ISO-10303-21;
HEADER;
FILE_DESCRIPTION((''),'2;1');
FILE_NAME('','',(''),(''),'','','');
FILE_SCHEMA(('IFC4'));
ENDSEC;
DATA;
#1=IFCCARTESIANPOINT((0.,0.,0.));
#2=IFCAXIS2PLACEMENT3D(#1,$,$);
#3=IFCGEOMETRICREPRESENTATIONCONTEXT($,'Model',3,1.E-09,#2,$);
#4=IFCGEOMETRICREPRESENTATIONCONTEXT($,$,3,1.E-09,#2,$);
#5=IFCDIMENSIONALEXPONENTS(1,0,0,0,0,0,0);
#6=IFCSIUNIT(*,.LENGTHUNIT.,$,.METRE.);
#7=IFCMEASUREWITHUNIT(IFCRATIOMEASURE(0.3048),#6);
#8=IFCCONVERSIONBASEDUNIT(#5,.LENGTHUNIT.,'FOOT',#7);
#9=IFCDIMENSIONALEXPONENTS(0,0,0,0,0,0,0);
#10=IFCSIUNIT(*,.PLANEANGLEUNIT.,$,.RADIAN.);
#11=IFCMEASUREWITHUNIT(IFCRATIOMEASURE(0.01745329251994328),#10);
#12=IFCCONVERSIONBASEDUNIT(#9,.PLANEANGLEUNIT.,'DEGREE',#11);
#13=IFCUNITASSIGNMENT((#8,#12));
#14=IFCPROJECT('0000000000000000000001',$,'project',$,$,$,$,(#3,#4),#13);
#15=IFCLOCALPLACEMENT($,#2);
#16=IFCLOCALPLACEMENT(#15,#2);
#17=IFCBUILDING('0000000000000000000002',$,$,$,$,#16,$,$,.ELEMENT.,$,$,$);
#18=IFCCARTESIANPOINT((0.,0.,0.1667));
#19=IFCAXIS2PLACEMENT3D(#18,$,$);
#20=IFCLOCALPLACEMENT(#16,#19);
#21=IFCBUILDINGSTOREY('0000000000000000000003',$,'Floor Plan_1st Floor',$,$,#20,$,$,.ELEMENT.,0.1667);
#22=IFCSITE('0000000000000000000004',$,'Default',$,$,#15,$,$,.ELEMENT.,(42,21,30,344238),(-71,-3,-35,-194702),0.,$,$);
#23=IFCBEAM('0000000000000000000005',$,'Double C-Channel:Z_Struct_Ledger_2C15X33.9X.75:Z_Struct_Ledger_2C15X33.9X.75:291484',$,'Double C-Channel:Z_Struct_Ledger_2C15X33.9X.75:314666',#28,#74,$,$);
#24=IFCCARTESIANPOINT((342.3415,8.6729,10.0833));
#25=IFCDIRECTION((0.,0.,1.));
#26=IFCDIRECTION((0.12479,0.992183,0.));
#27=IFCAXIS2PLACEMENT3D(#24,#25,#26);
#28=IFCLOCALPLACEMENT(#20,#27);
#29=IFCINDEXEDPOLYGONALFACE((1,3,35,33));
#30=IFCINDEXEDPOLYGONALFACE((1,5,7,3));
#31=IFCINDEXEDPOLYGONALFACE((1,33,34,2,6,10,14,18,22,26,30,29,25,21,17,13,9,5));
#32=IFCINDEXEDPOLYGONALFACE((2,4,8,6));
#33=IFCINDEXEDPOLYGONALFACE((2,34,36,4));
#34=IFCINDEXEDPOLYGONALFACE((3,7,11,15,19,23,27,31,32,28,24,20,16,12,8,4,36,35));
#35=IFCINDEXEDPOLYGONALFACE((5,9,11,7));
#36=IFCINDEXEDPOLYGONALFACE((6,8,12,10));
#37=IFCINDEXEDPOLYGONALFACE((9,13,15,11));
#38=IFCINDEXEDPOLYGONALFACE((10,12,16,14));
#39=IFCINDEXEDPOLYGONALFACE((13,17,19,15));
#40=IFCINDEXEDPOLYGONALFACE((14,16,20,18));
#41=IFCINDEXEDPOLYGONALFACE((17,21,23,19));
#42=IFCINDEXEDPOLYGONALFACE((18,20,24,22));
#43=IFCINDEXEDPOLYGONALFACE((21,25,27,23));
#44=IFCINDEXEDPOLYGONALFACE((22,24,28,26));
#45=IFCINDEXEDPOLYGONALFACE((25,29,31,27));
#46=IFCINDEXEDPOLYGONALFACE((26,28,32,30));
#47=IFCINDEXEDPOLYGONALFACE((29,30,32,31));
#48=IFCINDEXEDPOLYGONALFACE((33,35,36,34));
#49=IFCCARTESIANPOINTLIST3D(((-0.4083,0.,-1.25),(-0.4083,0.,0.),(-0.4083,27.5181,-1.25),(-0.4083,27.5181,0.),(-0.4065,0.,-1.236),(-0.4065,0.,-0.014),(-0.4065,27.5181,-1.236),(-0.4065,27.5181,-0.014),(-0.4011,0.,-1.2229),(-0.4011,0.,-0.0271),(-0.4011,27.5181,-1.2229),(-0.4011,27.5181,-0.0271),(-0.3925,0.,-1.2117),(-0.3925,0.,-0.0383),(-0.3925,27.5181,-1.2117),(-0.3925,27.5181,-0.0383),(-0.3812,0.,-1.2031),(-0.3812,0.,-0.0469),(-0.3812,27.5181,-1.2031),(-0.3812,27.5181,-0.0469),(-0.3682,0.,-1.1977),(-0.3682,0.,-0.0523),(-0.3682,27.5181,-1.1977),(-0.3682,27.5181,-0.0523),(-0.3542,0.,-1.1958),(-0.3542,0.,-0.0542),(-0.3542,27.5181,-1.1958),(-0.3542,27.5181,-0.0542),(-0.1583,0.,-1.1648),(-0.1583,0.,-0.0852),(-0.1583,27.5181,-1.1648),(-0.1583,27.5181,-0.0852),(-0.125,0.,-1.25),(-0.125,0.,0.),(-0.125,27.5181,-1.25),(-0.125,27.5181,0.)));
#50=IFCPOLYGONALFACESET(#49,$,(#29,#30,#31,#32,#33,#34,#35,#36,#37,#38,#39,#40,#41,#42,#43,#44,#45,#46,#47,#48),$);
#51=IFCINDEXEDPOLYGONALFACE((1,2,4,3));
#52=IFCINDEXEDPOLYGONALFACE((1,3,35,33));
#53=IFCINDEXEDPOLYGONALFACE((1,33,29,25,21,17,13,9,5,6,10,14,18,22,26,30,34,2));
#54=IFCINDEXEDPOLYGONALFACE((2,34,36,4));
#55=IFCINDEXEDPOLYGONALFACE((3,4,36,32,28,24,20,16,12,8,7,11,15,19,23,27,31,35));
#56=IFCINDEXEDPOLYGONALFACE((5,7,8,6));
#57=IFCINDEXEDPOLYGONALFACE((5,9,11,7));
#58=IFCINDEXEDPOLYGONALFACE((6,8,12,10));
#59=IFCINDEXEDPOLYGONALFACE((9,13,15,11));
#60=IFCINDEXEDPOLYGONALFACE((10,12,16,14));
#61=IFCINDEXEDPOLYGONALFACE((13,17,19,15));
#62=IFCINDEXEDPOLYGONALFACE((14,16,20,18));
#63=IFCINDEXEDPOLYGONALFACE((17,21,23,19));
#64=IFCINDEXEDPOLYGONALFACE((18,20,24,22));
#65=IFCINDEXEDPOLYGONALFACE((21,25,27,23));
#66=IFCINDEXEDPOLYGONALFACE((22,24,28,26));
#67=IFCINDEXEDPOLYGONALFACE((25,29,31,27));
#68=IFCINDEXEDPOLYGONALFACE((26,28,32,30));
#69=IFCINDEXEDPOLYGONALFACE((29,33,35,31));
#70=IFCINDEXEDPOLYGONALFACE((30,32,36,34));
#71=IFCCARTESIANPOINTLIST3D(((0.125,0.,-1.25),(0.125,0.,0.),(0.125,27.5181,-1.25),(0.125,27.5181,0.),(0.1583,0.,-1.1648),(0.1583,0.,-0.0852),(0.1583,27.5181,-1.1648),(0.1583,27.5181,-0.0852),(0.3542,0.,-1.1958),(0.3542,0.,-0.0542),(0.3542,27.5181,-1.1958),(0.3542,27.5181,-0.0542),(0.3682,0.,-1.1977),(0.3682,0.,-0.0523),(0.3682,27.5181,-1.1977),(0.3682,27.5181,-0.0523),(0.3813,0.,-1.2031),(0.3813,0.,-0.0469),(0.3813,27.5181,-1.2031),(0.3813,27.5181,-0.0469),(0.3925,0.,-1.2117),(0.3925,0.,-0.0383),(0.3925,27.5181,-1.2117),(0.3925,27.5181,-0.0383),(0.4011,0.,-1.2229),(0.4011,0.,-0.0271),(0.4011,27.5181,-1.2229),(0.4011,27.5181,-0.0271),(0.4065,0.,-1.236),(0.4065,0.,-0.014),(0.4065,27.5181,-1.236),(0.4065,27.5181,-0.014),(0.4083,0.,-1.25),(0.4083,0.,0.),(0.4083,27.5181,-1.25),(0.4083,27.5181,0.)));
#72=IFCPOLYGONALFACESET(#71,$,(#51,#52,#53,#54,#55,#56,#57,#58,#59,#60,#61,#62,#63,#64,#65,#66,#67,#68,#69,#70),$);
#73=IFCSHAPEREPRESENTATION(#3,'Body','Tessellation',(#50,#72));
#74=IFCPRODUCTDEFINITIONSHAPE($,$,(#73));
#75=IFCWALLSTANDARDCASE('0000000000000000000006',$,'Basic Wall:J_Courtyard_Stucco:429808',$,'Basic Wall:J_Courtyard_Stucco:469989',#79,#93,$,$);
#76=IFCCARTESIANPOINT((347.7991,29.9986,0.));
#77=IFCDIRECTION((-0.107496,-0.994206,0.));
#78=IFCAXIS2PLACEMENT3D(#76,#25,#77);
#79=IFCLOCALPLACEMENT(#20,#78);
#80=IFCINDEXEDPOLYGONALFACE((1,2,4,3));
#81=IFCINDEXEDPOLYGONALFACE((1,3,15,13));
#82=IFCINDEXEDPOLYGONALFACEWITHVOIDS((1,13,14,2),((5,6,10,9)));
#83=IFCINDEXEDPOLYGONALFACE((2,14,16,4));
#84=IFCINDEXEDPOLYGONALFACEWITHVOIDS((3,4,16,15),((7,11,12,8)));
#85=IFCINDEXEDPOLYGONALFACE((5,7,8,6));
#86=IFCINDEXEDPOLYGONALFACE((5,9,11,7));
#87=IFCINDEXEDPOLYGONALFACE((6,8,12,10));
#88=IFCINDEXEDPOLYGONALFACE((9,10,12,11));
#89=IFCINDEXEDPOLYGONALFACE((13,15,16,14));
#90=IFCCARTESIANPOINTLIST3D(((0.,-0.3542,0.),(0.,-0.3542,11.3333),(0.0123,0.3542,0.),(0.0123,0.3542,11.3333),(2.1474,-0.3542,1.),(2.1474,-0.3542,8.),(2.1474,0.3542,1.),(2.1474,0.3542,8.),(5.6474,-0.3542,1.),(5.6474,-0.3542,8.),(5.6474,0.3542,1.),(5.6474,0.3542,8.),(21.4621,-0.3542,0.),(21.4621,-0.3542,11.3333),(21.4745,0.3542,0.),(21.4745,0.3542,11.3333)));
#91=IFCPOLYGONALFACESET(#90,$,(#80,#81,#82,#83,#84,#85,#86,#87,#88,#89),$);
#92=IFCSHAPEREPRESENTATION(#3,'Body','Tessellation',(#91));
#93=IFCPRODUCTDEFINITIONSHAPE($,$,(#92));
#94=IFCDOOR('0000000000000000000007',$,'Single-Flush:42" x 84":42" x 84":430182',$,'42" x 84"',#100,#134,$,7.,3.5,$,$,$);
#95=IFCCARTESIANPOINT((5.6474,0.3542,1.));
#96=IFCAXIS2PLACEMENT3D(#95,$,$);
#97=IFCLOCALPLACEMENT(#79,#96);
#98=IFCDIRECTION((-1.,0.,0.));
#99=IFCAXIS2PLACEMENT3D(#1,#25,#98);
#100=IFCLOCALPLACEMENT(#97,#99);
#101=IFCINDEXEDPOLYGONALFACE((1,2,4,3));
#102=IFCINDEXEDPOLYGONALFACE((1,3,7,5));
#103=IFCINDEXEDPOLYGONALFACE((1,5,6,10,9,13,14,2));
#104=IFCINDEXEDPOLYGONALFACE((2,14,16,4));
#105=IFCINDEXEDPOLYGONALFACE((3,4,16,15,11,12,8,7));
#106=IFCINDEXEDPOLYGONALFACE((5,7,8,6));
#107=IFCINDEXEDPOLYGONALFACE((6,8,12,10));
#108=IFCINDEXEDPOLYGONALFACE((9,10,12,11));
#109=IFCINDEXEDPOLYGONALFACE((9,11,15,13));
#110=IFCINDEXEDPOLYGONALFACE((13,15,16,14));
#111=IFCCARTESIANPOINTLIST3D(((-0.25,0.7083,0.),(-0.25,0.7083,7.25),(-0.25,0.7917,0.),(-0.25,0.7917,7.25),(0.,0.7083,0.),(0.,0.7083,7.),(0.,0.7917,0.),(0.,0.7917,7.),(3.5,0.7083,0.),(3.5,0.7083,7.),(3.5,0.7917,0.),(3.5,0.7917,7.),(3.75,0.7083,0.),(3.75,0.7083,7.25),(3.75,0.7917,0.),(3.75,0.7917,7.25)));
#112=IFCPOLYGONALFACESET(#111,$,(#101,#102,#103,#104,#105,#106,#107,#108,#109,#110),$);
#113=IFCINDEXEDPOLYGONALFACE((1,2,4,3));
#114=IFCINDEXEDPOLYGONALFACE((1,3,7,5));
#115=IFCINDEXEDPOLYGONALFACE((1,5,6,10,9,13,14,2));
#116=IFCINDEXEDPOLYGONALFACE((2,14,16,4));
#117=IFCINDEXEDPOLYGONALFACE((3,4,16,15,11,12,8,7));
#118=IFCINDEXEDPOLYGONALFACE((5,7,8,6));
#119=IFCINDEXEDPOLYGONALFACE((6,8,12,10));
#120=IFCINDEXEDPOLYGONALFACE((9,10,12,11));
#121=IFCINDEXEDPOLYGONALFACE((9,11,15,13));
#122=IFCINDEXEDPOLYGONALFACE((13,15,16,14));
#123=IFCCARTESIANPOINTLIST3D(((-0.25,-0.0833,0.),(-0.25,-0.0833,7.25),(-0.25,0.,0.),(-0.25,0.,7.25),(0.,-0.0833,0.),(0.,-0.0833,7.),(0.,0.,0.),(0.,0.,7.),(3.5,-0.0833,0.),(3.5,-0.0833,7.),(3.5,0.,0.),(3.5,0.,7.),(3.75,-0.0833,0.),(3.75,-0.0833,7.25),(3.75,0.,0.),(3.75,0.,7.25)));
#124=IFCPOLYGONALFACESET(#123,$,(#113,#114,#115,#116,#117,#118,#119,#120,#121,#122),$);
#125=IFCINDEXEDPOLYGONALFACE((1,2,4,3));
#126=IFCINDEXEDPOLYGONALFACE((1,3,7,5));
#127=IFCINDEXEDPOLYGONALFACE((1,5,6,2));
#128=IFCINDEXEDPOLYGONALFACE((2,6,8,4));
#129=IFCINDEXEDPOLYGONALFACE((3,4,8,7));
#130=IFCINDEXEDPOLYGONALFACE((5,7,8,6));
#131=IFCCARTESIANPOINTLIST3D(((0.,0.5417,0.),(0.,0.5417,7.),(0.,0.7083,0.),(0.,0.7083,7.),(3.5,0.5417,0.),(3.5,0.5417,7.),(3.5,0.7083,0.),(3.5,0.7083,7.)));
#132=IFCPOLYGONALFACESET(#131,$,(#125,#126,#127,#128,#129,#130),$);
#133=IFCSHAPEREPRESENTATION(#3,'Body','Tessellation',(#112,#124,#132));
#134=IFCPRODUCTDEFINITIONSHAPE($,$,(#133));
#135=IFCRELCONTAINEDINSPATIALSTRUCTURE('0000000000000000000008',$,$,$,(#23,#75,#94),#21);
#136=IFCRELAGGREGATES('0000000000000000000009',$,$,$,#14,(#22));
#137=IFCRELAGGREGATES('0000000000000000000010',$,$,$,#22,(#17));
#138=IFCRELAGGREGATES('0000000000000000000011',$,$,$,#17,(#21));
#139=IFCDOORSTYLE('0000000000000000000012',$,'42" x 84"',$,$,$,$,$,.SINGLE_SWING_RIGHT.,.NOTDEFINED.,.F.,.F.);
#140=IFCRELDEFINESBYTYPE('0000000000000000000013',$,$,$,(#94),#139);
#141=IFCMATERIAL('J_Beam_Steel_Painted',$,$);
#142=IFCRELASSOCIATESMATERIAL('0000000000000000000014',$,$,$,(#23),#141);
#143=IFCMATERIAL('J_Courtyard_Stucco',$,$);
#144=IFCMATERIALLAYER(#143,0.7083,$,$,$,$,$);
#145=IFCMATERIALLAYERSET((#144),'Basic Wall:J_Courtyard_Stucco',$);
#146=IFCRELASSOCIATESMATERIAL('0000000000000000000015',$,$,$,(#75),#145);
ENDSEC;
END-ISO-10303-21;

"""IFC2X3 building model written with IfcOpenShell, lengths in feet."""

from ifc_helpers import new_model, entity, si_unit, converted_unit, frame, frame_2d, origin, origin_2d_with_axis, place, context, project, spatial, polyline, circle_curve, parameter, trimmed, segment, composite_curve, rectangle, outline, extrude, clip, halfspace, source, transform, mapped, material, layer, layer_set, layer_usage, type_object, type_shapes, element, fill, save


model = new_model("IFC2X3")

# Units and contexts
model_context = context("Model", 3, precision=1e-09, world=origin())
context_of_model = context(None, 3, precision=1e-09, world=origin())
ifc_project = project(units=[converted_unit("LENGTHUNIT", "FOOT", entity("IfcRatioMeasure", 0.3048), si_unit("LENGTHUNIT", "METRE"), dimensions=[1, 0, 0, 0, 0, 0, 0]), converted_unit("PLANEANGLEUNIT", "DEGREE", entity("IfcRatioMeasure", 0.01745329251994328), si_unit("PLANEANGLEUNIT", "RADIAN"), dimensions=[0, 0, 0, 0, 0, 0, 0])], contexts=[model_context, context_of_model])

# Site, building, storey
site_placement = place(None, origin())
site = spatial("IfcSite", under=ifc_project, at=site_placement, Name="Default", CompositionType="ELEMENT", RefLatitude=(42, 21, 30, 344238), RefLongitude=(-71, -3, -35, -194702), RefElevation=0.0)
building_placement = place(site_placement, origin())
building = spatial("IfcBuilding", under=site, at=building_placement, CompositionType="ELEMENT")
storey_placement = place(building_placement, frame((0.0, 0.0, 0.1667)))
storey = spatial("IfcBuildingStorey", under=building, at=storey_placement, Name="Floor Plan_1st Floor", CompositionType="ELEMENT", Elevation=0.1667)

# Beam
ifc_material_1 = material(Name="J_Beam_Steel_Painted")
beam_placement = place(storey_placement, frame((342.3415, 8.6729, 10.0833), z_axis=(0.0, 0.0, 1.0), x_axis=(0.12479, 0.992183, 0.0)))
element("IfcBeam", 1, at=beam_placement, inside=storey, material=ifc_material_1, Name="Double C-Channel:Z_Struct_Ledger_2C15X33.9X.75:Z_Struct_Ledger_2C15X33.9X.75:291484", ObjectType="Double C-Channel:Z_Struct_Ledger_2C15X33.9X.75:314666", context=model_context, shape_type="SweptSolid", body=[
    extrude(outline(composite_curve([segment(polyline([(-0.1365, -0.625), (0.1469, -0.625)]), True, "CONTINUOUS"), segment(trimmed(circle_curve(frame_2d((0.0927, -0.625), x_axis=(1.0, 0.0)), 0.0542), [parameter(0.0)], [parameter(90.0)], True, "PARAMETER"), True, "CONTINUOUS"), segment(polyline([(0.0927, -0.5708), (-0.1031, -0.5398)]), True, "CONTINUOUS"), segment(polyline([(-0.1031, -0.5398), (-0.1031, 0.5398)]), True, "CONTINUOUS"), segment(polyline([(-0.1031, 0.5398), (0.0927, 0.5708)]), True, "CONTINUOUS"), segment(trimmed(circle_curve(frame_2d((0.0927, 0.625), x_axis=(1.0, 0.0)), 0.0542), [parameter(270.0)], [parameter(0.0)], True, "PARAMETER"), True, "CONTINUOUS"), segment(polyline([(0.1469, 0.625), (-0.1365, 0.625)]), True, "CONTINUOUS"), segment(polyline([(-0.1365, 0.625), (-0.1365, -0.625)]), True, "CONTINUOUS")], self_intersect=False)), frame((-0.2615, 27.5181, -0.625), z_axis=(0.0, -1.0, 0.0), x_axis=(-1.0, 0.0, 0.0)), (0.0, 0.0, 1.0), 27.5181),
    extrude(outline(composite_curve([segment(polyline([(-0.625, -0.1365), (0.625, -0.1365)]), True, "CONTINUOUS"), segment(polyline([(0.625, -0.1365), (0.625, 0.1469)]), True, "CONTINUOUS"), segment(trimmed(circle_curve(frame_2d((0.625, 0.0927), x_axis=(0.0, 1.0)), 0.0542), [parameter(360.0)], [parameter(90.0)], True, "PARAMETER"), True, "CONTINUOUS"), segment(polyline([(0.5708, 0.0927), (0.5398, -0.1031)]), True, "CONTINUOUS"), segment(polyline([(0.5398, -0.1031), (-0.5398, -0.1031)]), True, "CONTINUOUS"), segment(polyline([(-0.5398, -0.1031), (-0.5708, 0.0927)]), True, "CONTINUOUS"), segment(trimmed(circle_curve(frame_2d((-0.625, 0.0927), x_axis=(0.0, 1.0)), 0.0542), [parameter(270.0)], [parameter(360.0)], True, "PARAMETER"), True, "CONTINUOUS"), segment(polyline([(-0.625, 0.1469), (-0.625, -0.1365)]), True, "CONTINUOUS")], self_intersect=False)), frame((0.2615, 27.5181, -0.625), z_axis=(0.0, -1.0, 0.0), x_axis=(0.0, 0.0, -1.0)), (0.0, 0.0, 1.0), 27.5181),
])

# Wall, opening, door
ifc_material_2 = material(Name="J_Courtyard_Stucco")
ifc_layer_1 = layer(ifc_material_2, 0.7083)
ifc_layer_set_1 = layer_set([ifc_layer_1], Name="Basic Wall:J_Courtyard_Stucco")
ifc_layer_usage_1 = layer_usage(ifc_layer_set_1, "AXIS2", "POSITIVE", -0.3542)
wall_1_placement = place(storey_placement, frame((347.7991, 29.9986, 0.0), z_axis=(0.0, 0.0, 1.0), x_axis=(-0.107496, -0.994206, 0.0)))
wall_1 = element("IfcWallStandardCase", 2, at=wall_1_placement, inside=storey, material=ifc_layer_usage_1, Name="Basic Wall:J_Courtyard_Stucco:429808", ObjectType="Basic Wall:J_Courtyard_Stucco:469989", context=model_context, shape_type="Clipping", body=[
    clip(extrude(outline(polyline([(21.4621, -0.3542), (21.4745, 0.3542), (0.0123, 0.3542), (0.0, -0.3542), (21.4621, -0.3542)])), origin(), (0.0, 0.0, 1.0), 11.3333), halfspace(origin(), True)),
])
opening_1_placement = place(wall_1_placement, frame((5.6474, 0.3542, 1.0)))
opening_1 = element("IfcOpeningElement", 3, at=opening_1_placement, cuts=wall_1, ObjectType="Opening", context=model_context, shape_type="SweptSolid", body=[
    extrude(rectangle(XDim=3.5, YDim=7.0, at=frame_2d((3.5, 1.75), x_axis=(0.0, 1.0))), frame((0.0, 0.0, 0.0), z_axis=(0.0, -1.0, 0.0), x_axis=(0.0, 0.0, 1.0)), (0.0, 0.0, 1.0), 0.7083),
])
door_style_1 = type_object("IfcDoorStyle", Name="42\" x 84\"", ConstructionType="NOTDEFINED", OperationType="SINGLE_SWING_RIGHT", ParameterTakesPrecedence=False, Sizeable=False)
shared_shape_1 = source(origin(), model_context, "Body", "SweptSolid", [
    extrude(outline(polyline([(-2.0, -3.6875), (2.0, -3.6875), (2.0, 3.5625), (1.75, 3.5625), (1.75, -3.4375), (-1.75, -3.4375), (-1.75, 3.5625), (-2.0, 3.5625), (-2.0, -3.6875)])), frame((1.75, 0.7083, 3.5625), z_axis=(0.0, 1.0, 0.0), x_axis=(1.0, 0.0, 0.0)), (0.0, 0.0, 1.0), 0.0833),
    extrude(outline(polyline([(-3.6875, -2.0), (3.5625, -2.0), (3.5625, -1.75), (-3.4375, -1.75), (-3.4375, 1.75), (3.5625, 1.75), (3.5625, 2.0), (-3.6875, 2.0), (-3.6875, -2.0)])), frame((1.75, -0.0833, 3.5625), z_axis=(0.0, 1.0, 0.0), x_axis=(0.0, 0.0, -1.0)), (0.0, 0.0, 1.0), 0.0833),
    extrude(rectangle(XDim=0.1667, YDim=3.5, at=origin_2d_with_axis()), frame((1.75, 0.625, 0.0), z_axis=(0.0, 0.0, 1.0), x_axis=(0.0, 1.0, 0.0)), (0.0, 0.0, 1.0), 7.0),
])
type_shapes(door_style_1, [shared_shape_1])
door_1_placement = place(opening_1_placement, frame((0.0, 0.0, 0.0), z_axis=(0.0, 0.0, 1.0), x_axis=(-1.0, 0.0, 0.0)))
door_1 = element("IfcDoor", 4, at=door_1_placement, inside=storey, type_object=door_style_1, Name="Single-Flush:42\" x 84\":42\" x 84\":430182", ObjectType="42\" x 84\"", OverallHeight=7.0, OverallWidth=3.5, context=model_context, shape_type="MappedRepresentation", body=[
    mapped(shared_shape_1, transform((0.0, 0.0, 0.0), scale=1.0)),
])
fill(opening_1, door_1)

save(model, "model.ifc")
